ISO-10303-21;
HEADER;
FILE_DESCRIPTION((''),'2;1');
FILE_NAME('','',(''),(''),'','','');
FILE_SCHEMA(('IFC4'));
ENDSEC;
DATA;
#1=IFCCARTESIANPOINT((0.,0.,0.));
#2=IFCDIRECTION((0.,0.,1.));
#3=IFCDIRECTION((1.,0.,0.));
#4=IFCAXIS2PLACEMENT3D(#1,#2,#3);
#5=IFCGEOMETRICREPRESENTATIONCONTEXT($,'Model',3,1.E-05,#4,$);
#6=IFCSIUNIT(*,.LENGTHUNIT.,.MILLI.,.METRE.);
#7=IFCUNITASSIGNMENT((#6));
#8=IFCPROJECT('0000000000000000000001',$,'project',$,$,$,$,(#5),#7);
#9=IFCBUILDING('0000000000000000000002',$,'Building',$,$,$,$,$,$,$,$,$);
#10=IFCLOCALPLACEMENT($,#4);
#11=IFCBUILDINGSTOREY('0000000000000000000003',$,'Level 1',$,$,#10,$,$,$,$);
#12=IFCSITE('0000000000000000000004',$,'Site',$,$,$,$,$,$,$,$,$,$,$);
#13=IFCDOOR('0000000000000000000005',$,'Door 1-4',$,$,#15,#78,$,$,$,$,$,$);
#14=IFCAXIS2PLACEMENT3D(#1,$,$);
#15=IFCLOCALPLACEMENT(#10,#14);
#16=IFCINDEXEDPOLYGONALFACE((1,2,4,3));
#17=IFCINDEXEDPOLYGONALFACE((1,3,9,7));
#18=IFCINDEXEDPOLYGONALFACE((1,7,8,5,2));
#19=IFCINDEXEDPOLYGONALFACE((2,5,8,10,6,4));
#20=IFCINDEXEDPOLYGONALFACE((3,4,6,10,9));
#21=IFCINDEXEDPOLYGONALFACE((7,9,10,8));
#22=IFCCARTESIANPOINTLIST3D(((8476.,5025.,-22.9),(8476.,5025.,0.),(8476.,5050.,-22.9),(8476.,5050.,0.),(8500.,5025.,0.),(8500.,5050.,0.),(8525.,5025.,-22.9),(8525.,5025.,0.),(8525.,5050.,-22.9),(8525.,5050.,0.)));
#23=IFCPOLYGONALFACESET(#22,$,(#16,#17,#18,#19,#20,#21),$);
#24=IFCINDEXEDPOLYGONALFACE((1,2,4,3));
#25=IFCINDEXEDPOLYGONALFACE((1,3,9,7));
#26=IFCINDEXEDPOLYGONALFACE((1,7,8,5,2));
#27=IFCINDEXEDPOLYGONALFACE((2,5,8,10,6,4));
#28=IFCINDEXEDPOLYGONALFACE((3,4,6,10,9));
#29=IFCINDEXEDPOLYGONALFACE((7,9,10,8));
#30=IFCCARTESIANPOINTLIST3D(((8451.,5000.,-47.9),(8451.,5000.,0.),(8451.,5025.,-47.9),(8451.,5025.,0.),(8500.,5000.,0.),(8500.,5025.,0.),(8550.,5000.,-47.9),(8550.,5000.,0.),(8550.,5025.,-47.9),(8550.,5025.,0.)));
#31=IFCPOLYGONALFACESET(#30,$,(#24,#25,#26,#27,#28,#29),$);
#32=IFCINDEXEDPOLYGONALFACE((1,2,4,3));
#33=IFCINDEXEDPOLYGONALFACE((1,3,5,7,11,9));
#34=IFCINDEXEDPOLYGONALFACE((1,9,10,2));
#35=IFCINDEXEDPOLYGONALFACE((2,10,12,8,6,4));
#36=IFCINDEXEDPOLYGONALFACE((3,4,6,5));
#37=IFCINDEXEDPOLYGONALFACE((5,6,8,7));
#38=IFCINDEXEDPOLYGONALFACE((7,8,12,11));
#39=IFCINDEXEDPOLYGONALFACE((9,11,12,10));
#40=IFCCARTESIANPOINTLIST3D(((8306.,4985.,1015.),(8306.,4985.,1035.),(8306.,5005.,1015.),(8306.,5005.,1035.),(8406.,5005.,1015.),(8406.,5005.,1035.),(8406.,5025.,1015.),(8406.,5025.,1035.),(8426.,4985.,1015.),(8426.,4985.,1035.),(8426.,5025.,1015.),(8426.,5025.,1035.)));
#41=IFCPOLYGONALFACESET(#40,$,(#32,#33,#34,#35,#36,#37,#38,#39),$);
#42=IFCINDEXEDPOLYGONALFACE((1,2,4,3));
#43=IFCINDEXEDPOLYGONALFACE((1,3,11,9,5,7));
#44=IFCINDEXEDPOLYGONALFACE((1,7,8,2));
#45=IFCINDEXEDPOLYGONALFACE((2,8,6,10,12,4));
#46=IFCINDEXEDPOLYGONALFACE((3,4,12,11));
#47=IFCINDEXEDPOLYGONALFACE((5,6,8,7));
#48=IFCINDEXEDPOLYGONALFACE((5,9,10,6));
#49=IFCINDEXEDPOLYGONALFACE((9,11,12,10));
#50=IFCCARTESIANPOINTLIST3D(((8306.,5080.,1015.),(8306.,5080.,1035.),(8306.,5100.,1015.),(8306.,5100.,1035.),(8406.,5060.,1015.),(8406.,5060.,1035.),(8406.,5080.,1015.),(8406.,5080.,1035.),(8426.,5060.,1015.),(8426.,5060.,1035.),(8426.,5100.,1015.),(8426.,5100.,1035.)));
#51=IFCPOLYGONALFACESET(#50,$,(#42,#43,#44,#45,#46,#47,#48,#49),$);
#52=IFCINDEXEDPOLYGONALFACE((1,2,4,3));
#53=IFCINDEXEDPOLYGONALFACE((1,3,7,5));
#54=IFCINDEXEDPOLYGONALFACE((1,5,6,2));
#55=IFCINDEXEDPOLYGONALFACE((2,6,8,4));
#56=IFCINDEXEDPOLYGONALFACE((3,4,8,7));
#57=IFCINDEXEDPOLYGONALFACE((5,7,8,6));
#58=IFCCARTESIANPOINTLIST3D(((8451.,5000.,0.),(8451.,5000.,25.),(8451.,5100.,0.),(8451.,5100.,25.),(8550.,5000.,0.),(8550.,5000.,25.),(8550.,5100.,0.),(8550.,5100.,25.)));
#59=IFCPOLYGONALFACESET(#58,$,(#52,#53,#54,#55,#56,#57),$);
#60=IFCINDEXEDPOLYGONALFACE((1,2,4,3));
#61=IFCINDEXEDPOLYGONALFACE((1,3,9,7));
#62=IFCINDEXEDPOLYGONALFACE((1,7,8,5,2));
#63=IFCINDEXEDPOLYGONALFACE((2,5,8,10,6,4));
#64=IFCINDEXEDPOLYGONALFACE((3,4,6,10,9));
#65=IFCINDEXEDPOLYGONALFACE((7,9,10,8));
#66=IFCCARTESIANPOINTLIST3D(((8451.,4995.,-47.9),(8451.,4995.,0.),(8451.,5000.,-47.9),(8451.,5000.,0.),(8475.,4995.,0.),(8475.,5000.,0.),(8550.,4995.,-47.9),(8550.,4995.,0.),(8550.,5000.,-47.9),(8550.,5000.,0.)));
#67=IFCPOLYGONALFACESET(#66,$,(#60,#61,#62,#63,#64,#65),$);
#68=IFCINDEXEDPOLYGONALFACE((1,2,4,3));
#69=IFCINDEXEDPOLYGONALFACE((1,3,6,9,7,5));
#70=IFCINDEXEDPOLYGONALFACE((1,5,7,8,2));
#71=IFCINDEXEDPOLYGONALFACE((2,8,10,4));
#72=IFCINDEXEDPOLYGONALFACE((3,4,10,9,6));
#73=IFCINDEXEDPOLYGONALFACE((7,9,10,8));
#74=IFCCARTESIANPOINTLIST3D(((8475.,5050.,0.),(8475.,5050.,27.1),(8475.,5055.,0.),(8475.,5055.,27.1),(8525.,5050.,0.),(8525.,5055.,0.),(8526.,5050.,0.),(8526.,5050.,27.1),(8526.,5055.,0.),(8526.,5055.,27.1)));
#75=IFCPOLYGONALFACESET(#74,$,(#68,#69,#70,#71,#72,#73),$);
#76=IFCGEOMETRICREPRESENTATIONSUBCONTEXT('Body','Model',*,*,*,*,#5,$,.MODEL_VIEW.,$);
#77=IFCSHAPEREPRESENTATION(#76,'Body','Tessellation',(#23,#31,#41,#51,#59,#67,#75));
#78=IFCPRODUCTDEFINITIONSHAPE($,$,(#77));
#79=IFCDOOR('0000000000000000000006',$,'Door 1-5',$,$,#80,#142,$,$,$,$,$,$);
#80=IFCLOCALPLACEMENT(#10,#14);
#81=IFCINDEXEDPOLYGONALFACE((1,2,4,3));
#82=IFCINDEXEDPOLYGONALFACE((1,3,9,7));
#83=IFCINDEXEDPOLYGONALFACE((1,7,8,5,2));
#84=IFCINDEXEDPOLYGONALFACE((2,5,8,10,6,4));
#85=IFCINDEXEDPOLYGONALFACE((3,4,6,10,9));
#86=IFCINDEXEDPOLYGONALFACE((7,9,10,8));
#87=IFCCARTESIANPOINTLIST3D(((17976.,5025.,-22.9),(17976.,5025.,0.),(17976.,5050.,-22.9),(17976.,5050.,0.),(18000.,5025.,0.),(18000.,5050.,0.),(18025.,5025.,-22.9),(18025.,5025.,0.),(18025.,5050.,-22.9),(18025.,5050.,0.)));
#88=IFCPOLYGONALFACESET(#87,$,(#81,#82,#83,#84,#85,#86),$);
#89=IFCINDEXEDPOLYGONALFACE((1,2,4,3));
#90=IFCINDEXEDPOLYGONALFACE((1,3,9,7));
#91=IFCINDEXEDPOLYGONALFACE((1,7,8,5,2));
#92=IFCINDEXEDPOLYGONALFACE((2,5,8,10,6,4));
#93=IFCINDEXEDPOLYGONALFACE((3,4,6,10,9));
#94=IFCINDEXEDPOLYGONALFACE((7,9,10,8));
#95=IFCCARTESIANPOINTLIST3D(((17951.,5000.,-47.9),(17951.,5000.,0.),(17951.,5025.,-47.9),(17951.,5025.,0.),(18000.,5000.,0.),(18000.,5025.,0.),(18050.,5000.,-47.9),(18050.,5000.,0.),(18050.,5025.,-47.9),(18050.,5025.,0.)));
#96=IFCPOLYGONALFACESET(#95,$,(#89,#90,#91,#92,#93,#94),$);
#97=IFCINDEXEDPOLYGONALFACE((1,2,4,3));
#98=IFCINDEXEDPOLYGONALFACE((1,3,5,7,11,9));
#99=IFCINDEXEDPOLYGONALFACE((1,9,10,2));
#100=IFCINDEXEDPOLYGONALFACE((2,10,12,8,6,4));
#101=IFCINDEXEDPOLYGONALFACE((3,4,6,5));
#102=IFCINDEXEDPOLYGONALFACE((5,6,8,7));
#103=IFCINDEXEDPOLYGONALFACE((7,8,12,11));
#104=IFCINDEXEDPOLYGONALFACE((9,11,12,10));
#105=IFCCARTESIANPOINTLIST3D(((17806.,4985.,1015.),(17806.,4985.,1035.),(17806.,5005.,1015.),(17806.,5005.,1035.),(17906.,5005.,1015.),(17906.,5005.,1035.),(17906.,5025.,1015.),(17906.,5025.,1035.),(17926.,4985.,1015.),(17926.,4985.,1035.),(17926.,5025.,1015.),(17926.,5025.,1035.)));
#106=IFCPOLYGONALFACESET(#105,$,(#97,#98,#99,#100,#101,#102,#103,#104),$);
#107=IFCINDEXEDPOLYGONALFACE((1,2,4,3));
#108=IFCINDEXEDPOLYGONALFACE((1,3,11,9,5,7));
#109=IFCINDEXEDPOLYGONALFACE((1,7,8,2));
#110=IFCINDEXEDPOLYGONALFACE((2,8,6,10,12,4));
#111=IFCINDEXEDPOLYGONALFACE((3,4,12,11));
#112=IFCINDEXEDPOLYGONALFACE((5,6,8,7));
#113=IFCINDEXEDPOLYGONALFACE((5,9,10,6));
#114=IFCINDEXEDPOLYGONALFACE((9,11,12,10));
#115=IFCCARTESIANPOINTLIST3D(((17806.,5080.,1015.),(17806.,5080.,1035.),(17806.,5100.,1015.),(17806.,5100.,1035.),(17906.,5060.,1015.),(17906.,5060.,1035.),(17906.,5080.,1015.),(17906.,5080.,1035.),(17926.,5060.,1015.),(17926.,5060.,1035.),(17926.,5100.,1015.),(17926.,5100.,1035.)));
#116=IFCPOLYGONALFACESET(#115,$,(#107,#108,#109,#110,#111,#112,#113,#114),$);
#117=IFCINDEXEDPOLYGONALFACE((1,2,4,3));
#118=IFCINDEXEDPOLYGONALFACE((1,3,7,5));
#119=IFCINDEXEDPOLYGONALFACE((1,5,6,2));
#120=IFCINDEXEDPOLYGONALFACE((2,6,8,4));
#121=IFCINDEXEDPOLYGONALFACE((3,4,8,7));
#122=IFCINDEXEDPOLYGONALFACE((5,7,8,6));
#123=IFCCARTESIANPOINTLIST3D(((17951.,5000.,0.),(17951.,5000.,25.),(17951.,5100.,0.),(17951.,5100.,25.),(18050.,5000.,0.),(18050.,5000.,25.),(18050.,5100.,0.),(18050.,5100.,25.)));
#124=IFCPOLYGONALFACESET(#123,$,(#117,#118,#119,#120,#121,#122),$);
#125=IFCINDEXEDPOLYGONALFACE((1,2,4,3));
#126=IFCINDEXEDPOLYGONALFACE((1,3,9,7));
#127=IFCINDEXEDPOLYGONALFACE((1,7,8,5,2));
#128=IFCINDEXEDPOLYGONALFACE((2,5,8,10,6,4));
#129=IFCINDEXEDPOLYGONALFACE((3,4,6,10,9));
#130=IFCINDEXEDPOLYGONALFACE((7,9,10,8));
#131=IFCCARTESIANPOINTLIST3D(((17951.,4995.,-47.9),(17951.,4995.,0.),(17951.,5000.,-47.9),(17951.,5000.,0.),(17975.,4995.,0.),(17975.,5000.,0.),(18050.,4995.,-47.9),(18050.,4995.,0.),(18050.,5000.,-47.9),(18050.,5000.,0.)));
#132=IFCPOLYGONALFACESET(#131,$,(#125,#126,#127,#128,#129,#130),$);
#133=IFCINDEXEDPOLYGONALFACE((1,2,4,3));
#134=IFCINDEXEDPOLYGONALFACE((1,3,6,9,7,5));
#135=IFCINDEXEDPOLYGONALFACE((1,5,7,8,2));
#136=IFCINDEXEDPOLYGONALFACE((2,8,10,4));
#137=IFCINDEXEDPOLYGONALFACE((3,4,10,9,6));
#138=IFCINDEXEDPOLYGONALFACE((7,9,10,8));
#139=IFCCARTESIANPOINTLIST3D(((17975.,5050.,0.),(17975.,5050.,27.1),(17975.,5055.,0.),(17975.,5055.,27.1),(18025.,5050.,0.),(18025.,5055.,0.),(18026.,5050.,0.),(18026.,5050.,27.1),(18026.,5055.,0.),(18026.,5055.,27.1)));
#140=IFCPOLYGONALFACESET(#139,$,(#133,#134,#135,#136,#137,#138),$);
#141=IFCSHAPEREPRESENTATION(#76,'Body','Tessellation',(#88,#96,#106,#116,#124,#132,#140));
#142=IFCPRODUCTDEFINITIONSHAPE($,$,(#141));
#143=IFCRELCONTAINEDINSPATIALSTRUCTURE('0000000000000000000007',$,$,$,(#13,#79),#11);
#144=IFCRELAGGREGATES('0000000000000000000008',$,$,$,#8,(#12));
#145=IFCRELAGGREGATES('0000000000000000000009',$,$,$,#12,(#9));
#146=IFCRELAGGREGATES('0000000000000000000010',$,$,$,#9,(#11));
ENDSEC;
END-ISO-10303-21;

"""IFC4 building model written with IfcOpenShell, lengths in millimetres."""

from ifc_helpers import new_model, si_unit, frame, origin_with_axes, place, context, subcontext, project, spatial, line, indexed_curve, outline, extrude, element, save


model = new_model("IFC4")

# Units and contexts
model_context = context("Model", 3, precision=1e-05, world=origin_with_axes())
body_context = subcontext(model_context, "Body", "Model", "MODEL_VIEW")
ifc_project = project(units=[si_unit("LENGTHUNIT", "METRE", prefix="MILLI")], contexts=[model_context])

# Site, building, storey
site = spatial("IfcSite", under=ifc_project, Name="Site")
building = spatial("IfcBuilding", under=site, Name="Building")
storey_placement = place(None, origin_with_axes())
storey = spatial("IfcBuildingStorey", under=building, at=storey_placement, Name="Level 1")

# Doors
door_1_placement = place(storey_placement, frame((8500.0, 5000.0, 0.0), z_axis=(0.0, 0.0, 1.0), x_axis=(1.0, 0.0, 0.0)))
element("IfcDoor", 1, at=door_1_placement, inside=storey, Name="Door 1-4", context=body_context, shape_type="SweptSolid", body=[
    extrude(outline(indexed_curve([(0.0, 0.0), (0.0, 2.1), (1.0, 2.1), (1.0, 0.0), (-24.0, 0.0), (-24.0, -22.9), (25.0, -22.9), (25.0, 0.0)], segments=[line(1, 2, 3, 4, 5, 6, 7, 8, 1)])), frame((0.0, 25.0, 0.0), z_axis=(0.0, -1.0, 0.0), x_axis=(1.0, 0.0, 0.0)), (0.0, 0.0, -1.0), 25.0),
    extrude(outline(indexed_curve([(0.0, 0.0), (0.0, 2.1), (1.0, 2.1), (1.0, 0.0), (-49.0, 0.0), (-49.0, -47.9), (50.0, -47.9), (50.0, 0.0)], segments=[line(1, 2, 3, 4, 5, 6, 7, 8, 1)])), frame((0.0, 0.0, 0.0), z_axis=(0.0, -1.0, 0.0), x_axis=(1.0, 0.0, 0.0)), (0.0, 0.0, -1.0), 25.0),
    extrude(outline(indexed_curve([(0.0, 0.0), (-49.0, 0.0), (-49.0, 35.0), (0.0, 35.0)], segments=[line(1, 2, 3, 4, 1)])), frame((25.0, 25.0, 25.0), z_axis=(0.0, 0.0, 1.0), x_axis=(1.0, 0.0, 0.0)), (0.0, 0.0, 1.0), -47.9),
    extrude(outline(indexed_curve([(0.0, 0.0), (0.0, -40.0), (-120.0, -40.0), (-120.0, -20.0), (-20.0, -20.0), (-20.0, 0.0)], segments=[line(1, 2, 3, 4, 5, 6, 1)])), frame((-74.0, 25.0, 1015.0), z_axis=(0.0, 0.0, 1.0), x_axis=(1.0, 0.0, 0.0)), (0.0, 0.0, 1.0), 20.0),
    extrude(outline(indexed_curve([(0.0, 0.0), (0.0, 40.0), (-120.0, 40.0), (-120.0, 20.0), (-20.0, 20.0), (-20.0, 0.0)], segments=[line(1, 2, 3, 4, 5, 6, 1)])), frame((-74.0, 60.0, 1015.0), z_axis=(0.0, 0.0, 1.0), x_axis=(1.0, 0.0, 0.0)), (0.0, 0.0, 1.0), 20.0),
    extrude(outline(indexed_curve([(0.0, 0.0), (-99.0, 0.0), (-99.0, 100.0), (0.0, 100.0)], segments=[line(1, 2, 3, 4, 1)])), frame((50.0, 0.0, 0.0), z_axis=(0.0, 0.0, 1.0), x_axis=(1.0, 0.0, 0.0)), (0.0, 0.0, 1.0), 25.0),
    extrude(outline(indexed_curve([(0.0, 0.0), (0.0, 27.1), (51.0, 27.1), (51.0, 0.0), (-24.0, 0.0), (-24.0, -47.9), (75.0, -47.9), (75.0, 0.0)], segments=[line(1, 2, 3, 4, 5, 6, 7, 8, 1)])), frame((-25.0, -5.0, 0.0), z_axis=(0.0, -1.0, 0.0), x_axis=(1.0, 0.0, 0.0)), (0.0, 0.0, -1.0), 5.0),
    extrude(outline(indexed_curve([(0.0, 0.0), (0.0, 27.1), (51.0, 27.1), (51.0, 0.0), (1.0, 0.0), (1.0, -22.9), (50.0, -22.9), (50.0, 0.0)], segments=[line(1, 2, 3, 4, 5, 6, 7, 8, 1)])), frame((-25.0, 50.0, 0.0), z_axis=(0.0, -1.0, 0.0), x_axis=(1.0, 0.0, 0.0)), (0.0, 0.0, -1.0), 5.0),
])
door_2_placement = place(storey_placement, frame((18000.0, 5000.0, 0.0), z_axis=(0.0, 0.0, 1.0), x_axis=(1.0, 0.0, 0.0)))
element("IfcDoor", 2, at=door_2_placement, inside=storey, Name="Door 1-5", context=body_context, shape_type="SweptSolid", body=[
    extrude(outline(indexed_curve([(0.0, 0.0), (0.0, 2.1), (1.0, 2.1), (1.0, 0.0), (-24.0, 0.0), (-24.0, -22.9), (25.0, -22.9), (25.0, 0.0)], segments=[line(1, 2, 3, 4, 5, 6, 7, 8, 1)])), frame((0.0, 25.0, 0.0), z_axis=(0.0, -1.0, 0.0), x_axis=(1.0, 0.0, 0.0)), (0.0, 0.0, -1.0), 25.0),
    extrude(outline(indexed_curve([(0.0, 0.0), (0.0, 2.1), (1.0, 2.1), (1.0, 0.0), (-49.0, 0.0), (-49.0, -47.9), (50.0, -47.9), (50.0, 0.0)], segments=[line(1, 2, 3, 4, 5, 6, 7, 8, 1)])), frame((0.0, 0.0, 0.0), z_axis=(0.0, -1.0, 0.0), x_axis=(1.0, 0.0, 0.0)), (0.0, 0.0, -1.0), 25.0),
    extrude(outline(indexed_curve([(0.0, 0.0), (-49.0, 0.0), (-49.0, 35.0), (0.0, 35.0)], segments=[line(1, 2, 3, 4, 1)])), frame((25.0, 25.0, 25.0), z_axis=(0.0, 0.0, 1.0), x_axis=(1.0, 0.0, 0.0)), (0.0, 0.0, 1.0), -47.9),
    extrude(outline(indexed_curve([(0.0, 0.0), (0.0, -40.0), (-120.0, -40.0), (-120.0, -20.0), (-20.0, -20.0), (-20.0, 0.0)], segments=[line(1, 2, 3, 4, 5, 6, 1)])), frame((-74.0, 25.0, 1015.0), z_axis=(0.0, 0.0, 1.0), x_axis=(1.0, 0.0, 0.0)), (0.0, 0.0, 1.0), 20.0),
    extrude(outline(indexed_curve([(0.0, 0.0), (0.0, 40.0), (-120.0, 40.0), (-120.0, 20.0), (-20.0, 20.0), (-20.0, 0.0)], segments=[line(1, 2, 3, 4, 5, 6, 1)])), frame((-74.0, 60.0, 1015.0), z_axis=(0.0, 0.0, 1.0), x_axis=(1.0, 0.0, 0.0)), (0.0, 0.0, 1.0), 20.0),
    extrude(outline(indexed_curve([(0.0, 0.0), (-99.0, 0.0), (-99.0, 100.0), (0.0, 100.0)], segments=[line(1, 2, 3, 4, 1)])), frame((50.0, 0.0, 0.0), z_axis=(0.0, 0.0, 1.0), x_axis=(1.0, 0.0, 0.0)), (0.0, 0.0, 1.0), 25.0),
    extrude(outline(indexed_curve([(0.0, 0.0), (0.0, 27.1), (51.0, 27.1), (51.0, 0.0), (-24.0, 0.0), (-24.0, -47.9), (75.0, -47.9), (75.0, 0.0)], segments=[line(1, 2, 3, 4, 5, 6, 7, 8, 1)])), frame((-25.0, -5.0, 0.0), z_axis=(0.0, -1.0, 0.0), x_axis=(1.0, 0.0, 0.0)), (0.0, 0.0, -1.0), 5.0),
    extrude(outline(indexed_curve([(0.0, 0.0), (0.0, 27.1), (51.0, 27.1), (51.0, 0.0), (1.0, 0.0), (1.0, -22.9), (50.0, -22.9), (50.0, 0.0)], segments=[line(1, 2, 3, 4, 5, 6, 7, 8, 1)])), frame((-25.0, 50.0, 0.0), z_axis=(0.0, -1.0, 0.0), x_axis=(1.0, 0.0, 0.0)), (0.0, 0.0, -1.0), 5.0),
])

save(model, "model.ifc")
